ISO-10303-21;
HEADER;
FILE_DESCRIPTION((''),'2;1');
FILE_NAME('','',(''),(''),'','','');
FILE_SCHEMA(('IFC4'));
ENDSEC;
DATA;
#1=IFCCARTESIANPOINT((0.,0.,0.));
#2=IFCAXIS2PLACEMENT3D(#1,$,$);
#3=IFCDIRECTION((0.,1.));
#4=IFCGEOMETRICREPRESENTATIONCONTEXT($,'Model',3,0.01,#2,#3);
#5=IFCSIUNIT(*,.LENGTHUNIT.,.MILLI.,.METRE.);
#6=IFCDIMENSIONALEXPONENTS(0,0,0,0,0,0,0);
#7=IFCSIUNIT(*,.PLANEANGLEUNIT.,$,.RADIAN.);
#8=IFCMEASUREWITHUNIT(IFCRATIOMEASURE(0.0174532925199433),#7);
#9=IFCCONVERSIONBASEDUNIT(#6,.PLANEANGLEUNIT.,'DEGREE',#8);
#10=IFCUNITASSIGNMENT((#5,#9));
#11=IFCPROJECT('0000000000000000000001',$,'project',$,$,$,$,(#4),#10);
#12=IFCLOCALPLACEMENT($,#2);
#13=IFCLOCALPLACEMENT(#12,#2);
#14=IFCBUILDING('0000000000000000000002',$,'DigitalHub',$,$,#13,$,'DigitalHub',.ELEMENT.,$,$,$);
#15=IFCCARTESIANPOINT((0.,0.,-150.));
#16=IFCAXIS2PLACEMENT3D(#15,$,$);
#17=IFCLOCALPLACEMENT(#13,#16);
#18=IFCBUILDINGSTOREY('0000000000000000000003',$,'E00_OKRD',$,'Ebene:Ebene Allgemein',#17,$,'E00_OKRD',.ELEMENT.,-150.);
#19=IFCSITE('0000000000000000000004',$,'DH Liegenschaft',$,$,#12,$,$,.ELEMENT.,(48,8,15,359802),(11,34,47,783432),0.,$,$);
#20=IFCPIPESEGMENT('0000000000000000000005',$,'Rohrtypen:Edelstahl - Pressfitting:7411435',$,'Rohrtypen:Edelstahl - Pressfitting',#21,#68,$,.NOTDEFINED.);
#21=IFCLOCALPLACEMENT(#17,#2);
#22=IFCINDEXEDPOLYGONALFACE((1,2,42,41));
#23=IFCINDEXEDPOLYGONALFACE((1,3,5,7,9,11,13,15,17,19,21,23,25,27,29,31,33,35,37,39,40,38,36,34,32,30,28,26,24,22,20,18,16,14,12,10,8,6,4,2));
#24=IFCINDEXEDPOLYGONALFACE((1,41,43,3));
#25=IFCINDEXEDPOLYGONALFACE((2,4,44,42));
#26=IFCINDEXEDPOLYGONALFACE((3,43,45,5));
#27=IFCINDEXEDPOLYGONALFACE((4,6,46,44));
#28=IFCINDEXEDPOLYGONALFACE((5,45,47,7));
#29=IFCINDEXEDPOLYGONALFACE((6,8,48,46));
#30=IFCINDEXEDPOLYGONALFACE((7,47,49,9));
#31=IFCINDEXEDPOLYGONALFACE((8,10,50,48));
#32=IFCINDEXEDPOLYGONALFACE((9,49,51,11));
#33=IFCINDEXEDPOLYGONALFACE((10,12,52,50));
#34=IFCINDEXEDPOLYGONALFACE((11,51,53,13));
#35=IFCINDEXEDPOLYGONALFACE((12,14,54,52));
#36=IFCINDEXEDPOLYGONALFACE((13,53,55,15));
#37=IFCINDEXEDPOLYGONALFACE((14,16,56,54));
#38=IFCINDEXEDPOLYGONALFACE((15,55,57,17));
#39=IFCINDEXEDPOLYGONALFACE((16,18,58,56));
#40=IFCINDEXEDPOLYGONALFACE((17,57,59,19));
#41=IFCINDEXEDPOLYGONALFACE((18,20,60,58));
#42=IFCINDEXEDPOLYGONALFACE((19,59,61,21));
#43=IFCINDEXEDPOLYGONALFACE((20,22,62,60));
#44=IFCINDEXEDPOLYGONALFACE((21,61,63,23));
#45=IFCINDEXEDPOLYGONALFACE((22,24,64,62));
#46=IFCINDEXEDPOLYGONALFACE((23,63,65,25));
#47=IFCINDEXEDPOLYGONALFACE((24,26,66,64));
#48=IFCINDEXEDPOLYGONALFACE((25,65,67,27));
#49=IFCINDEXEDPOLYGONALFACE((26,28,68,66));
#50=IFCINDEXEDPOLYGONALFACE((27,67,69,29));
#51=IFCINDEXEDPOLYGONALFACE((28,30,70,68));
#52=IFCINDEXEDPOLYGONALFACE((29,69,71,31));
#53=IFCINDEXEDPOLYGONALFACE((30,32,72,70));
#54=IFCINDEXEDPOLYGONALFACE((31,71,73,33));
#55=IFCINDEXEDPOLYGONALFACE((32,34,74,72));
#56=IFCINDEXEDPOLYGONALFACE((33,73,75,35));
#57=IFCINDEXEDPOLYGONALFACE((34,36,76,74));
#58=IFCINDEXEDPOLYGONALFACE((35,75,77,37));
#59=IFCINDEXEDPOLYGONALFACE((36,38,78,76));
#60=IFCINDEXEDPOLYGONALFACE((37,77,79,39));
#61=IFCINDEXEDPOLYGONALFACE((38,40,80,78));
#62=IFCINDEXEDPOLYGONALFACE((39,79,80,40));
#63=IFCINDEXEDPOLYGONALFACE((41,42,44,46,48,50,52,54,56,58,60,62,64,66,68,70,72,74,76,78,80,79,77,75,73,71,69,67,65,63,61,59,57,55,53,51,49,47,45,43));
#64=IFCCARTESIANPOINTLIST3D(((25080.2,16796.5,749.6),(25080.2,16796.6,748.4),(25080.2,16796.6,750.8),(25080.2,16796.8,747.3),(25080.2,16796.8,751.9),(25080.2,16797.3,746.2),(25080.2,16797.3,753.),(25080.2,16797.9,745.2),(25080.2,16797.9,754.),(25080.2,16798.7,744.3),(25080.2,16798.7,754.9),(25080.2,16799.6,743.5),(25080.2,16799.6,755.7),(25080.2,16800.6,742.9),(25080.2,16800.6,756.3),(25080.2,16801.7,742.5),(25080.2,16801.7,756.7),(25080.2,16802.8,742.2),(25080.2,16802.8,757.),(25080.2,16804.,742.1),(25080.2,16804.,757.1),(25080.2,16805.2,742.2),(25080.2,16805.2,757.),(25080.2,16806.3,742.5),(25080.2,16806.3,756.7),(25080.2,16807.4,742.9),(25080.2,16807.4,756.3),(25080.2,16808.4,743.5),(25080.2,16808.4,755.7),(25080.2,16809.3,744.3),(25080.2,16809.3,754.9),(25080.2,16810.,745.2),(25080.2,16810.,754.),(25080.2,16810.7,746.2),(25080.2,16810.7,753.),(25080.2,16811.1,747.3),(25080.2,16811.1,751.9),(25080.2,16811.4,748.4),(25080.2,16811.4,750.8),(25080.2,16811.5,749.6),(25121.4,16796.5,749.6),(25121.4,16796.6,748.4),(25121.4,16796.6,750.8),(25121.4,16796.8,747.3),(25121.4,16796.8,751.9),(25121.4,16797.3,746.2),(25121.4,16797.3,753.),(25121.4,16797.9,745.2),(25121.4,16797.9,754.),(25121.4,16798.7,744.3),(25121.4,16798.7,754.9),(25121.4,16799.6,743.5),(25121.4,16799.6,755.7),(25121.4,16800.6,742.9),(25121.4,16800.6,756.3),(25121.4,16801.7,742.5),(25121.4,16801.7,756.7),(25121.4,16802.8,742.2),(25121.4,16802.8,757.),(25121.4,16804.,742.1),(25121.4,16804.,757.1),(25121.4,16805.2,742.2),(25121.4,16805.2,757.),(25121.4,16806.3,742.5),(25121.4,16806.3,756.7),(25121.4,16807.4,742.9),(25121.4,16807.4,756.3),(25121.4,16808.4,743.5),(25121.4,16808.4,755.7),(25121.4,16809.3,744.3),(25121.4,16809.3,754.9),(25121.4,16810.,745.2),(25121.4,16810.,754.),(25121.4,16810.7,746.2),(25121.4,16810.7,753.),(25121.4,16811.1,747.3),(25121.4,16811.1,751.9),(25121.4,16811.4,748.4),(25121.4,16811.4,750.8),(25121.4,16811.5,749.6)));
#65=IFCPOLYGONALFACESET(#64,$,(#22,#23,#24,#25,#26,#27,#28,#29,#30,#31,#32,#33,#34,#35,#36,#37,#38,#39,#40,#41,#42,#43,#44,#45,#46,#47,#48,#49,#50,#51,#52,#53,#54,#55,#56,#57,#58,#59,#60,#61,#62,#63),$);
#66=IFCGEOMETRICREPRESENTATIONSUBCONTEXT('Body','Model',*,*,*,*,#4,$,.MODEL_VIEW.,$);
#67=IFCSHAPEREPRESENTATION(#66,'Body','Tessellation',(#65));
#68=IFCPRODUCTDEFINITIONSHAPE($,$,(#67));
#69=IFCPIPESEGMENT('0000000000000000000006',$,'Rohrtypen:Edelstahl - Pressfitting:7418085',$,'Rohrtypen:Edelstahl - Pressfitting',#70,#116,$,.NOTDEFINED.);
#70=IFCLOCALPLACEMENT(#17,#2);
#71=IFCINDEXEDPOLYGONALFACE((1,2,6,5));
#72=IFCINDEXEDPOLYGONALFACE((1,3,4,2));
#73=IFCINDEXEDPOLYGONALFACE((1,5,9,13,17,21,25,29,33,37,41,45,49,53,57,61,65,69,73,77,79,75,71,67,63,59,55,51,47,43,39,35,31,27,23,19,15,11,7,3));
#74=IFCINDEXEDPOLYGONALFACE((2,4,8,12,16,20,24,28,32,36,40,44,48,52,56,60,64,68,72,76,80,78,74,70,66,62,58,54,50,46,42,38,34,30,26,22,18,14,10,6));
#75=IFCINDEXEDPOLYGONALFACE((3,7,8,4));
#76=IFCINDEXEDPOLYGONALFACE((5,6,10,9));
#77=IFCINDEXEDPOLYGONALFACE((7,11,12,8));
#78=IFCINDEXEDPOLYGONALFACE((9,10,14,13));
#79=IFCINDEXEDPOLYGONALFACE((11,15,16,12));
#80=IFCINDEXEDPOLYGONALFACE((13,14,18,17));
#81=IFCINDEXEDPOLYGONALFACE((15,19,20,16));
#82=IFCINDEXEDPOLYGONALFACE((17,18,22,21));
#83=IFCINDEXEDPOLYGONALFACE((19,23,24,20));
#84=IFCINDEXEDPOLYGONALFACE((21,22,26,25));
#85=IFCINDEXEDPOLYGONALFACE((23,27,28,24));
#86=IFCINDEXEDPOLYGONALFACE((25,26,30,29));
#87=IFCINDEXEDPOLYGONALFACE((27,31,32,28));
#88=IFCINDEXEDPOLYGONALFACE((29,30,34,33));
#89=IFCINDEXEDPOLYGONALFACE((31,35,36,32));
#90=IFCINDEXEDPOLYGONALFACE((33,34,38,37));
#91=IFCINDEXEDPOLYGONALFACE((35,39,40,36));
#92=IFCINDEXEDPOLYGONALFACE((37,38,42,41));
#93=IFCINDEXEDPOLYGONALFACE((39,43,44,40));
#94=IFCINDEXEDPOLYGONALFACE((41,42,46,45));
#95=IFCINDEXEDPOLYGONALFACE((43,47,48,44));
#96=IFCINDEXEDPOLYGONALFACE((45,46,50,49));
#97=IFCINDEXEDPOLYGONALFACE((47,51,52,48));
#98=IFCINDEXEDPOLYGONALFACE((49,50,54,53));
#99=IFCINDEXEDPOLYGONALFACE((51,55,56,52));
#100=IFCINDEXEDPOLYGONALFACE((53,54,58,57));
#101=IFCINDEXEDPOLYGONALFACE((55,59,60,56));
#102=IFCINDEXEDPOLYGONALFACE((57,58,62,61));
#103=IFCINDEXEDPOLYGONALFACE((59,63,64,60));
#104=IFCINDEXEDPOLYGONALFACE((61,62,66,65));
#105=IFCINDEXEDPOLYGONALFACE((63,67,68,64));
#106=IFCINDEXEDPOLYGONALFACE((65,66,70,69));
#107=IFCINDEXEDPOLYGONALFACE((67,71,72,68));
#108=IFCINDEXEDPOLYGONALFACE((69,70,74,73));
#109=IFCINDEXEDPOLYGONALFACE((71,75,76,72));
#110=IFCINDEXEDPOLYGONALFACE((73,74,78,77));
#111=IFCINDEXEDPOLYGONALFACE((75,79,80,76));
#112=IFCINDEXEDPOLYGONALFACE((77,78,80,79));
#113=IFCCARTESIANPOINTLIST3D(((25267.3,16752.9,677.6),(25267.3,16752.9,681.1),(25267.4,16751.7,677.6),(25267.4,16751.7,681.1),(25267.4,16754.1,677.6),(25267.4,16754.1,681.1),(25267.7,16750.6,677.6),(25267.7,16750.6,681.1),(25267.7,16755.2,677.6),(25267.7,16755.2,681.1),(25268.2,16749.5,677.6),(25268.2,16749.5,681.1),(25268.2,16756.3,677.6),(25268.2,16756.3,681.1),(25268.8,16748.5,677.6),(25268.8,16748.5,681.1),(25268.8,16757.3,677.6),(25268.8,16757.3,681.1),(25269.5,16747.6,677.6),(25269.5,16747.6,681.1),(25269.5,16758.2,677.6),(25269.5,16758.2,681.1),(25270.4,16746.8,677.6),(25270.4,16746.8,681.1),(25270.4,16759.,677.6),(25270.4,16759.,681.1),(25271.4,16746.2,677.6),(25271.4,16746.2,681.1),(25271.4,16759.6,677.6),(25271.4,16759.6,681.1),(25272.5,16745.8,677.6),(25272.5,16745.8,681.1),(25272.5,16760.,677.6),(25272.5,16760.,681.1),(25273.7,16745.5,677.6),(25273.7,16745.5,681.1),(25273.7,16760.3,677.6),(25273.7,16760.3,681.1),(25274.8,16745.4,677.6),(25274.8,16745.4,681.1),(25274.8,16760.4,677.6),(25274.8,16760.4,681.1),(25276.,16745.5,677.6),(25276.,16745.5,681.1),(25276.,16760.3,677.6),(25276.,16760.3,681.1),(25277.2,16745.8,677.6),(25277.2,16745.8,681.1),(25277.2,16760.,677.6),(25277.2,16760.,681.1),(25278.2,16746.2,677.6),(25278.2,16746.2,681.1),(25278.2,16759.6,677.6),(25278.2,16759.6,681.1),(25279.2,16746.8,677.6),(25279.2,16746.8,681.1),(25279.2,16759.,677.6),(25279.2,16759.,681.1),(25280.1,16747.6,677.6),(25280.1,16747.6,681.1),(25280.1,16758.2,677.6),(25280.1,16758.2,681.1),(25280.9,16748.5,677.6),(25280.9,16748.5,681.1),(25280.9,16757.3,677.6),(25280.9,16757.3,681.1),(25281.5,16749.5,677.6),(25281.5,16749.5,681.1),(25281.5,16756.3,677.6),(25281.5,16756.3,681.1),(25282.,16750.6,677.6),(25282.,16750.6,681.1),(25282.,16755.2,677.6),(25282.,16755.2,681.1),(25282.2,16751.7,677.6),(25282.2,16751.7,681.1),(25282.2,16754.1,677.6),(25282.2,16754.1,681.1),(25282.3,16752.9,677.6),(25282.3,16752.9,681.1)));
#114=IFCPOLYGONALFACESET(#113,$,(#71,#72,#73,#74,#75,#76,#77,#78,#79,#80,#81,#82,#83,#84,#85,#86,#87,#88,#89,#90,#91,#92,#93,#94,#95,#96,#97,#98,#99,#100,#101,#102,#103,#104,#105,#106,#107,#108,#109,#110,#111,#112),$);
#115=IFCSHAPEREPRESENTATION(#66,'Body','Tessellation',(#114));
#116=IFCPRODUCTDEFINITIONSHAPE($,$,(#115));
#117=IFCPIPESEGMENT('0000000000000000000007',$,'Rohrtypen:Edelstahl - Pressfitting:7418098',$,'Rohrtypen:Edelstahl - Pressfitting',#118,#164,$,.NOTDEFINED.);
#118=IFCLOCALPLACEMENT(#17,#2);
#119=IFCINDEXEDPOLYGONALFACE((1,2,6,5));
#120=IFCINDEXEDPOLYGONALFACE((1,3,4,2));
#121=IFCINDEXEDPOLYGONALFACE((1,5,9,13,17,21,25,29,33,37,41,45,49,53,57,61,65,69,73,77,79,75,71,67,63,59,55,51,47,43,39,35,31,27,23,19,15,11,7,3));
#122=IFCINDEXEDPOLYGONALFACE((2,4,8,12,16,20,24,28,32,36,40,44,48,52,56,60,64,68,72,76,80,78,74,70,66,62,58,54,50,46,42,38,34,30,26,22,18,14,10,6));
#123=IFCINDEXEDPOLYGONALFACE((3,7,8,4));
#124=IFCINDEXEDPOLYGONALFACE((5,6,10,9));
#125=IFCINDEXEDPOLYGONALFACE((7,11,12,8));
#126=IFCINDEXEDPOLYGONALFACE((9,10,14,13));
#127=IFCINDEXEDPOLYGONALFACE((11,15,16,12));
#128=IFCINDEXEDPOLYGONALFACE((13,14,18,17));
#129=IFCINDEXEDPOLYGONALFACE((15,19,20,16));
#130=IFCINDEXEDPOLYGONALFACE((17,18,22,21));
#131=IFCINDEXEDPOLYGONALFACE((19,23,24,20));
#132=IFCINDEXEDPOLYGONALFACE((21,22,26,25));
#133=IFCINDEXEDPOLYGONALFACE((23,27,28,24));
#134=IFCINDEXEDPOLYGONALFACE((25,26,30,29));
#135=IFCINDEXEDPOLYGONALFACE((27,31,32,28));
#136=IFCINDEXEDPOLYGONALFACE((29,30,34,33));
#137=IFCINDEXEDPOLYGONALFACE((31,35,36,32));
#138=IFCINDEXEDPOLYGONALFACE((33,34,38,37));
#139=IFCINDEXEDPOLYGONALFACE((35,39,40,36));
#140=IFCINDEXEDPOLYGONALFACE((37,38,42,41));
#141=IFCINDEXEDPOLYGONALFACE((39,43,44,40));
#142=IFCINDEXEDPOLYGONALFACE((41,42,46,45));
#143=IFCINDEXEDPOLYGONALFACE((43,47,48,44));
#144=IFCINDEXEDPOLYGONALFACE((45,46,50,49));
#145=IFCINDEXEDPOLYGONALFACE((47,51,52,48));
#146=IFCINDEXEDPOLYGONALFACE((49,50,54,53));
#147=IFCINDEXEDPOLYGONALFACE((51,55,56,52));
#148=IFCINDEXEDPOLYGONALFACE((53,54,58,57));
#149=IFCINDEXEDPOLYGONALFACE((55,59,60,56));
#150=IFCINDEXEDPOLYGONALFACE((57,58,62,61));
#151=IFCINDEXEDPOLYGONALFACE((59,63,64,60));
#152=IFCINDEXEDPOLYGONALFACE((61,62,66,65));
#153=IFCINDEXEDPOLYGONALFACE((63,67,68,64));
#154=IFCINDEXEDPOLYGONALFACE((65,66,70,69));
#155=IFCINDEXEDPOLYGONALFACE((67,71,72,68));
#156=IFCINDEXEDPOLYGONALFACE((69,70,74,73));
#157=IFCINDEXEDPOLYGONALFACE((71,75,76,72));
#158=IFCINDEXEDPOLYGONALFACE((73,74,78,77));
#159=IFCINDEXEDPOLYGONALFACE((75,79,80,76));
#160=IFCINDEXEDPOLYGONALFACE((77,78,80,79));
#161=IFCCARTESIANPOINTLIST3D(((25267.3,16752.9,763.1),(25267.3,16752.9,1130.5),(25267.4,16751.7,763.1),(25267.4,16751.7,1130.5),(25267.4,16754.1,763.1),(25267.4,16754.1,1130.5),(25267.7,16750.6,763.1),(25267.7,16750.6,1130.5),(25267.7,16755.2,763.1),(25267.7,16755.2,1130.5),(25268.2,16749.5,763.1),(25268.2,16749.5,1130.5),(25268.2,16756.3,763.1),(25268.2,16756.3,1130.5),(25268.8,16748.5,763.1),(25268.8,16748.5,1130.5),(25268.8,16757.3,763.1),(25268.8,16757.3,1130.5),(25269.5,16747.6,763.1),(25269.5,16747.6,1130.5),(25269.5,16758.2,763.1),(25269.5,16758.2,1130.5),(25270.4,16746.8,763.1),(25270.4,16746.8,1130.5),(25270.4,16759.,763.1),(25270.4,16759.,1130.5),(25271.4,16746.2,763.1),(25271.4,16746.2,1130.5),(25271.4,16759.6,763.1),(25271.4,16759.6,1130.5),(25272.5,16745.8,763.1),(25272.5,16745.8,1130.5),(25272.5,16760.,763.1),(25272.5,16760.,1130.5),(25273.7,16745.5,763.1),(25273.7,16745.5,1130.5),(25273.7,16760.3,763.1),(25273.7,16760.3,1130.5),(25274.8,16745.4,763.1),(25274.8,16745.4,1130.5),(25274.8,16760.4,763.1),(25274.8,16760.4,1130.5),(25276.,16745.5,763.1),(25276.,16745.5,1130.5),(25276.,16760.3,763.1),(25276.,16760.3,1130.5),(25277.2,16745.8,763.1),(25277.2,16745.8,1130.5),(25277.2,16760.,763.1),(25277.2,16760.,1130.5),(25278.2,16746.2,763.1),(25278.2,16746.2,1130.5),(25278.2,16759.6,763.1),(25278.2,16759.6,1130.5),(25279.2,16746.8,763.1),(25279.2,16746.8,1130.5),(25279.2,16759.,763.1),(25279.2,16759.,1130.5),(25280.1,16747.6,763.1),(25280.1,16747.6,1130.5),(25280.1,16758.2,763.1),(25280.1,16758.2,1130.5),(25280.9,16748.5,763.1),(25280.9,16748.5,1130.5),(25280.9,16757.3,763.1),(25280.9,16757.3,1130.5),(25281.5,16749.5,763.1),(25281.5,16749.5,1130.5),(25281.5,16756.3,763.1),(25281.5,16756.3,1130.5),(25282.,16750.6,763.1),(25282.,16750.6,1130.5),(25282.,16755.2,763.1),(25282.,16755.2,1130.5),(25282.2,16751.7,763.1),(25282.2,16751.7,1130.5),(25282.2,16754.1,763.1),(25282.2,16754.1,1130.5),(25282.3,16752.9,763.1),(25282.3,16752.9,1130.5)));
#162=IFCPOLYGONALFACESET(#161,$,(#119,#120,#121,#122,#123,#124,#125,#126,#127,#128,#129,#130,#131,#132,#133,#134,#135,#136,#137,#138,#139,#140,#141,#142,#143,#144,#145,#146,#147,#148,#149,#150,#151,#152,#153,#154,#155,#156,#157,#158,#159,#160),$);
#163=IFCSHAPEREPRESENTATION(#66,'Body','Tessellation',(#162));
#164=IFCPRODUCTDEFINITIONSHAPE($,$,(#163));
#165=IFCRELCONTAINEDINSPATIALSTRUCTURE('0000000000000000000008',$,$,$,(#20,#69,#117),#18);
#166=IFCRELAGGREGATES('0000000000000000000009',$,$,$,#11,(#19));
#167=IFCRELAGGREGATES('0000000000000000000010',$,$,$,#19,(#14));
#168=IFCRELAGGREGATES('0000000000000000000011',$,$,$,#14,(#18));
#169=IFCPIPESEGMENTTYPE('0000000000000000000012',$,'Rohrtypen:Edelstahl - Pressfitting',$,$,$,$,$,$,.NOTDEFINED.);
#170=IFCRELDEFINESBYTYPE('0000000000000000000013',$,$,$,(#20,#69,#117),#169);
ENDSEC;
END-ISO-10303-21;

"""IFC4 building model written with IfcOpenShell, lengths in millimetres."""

from ifc_helpers import new_model, entity, si_unit, converted_unit, direction, frame, origin, place, context, subcontext, project, spatial, indexed_curve, outline, extrude, type_object, element, save


model = new_model("IFC4")

# Units and contexts
model_context = context("Model", 3, precision=0.01, world=origin(), true_north=direction((0.0, 1.0)))
body_context = subcontext(model_context, "Body", "Model", "MODEL_VIEW")
ifc_project = project(units=[si_unit("LENGTHUNIT", "METRE", prefix="MILLI"), converted_unit("PLANEANGLEUNIT", "DEGREE", entity("IfcRatioMeasure", 0.0174532925199433), si_unit("PLANEANGLEUNIT", "RADIAN"), dimensions=[0, 0, 0, 0, 0, 0, 0])], contexts=[model_context])

# Site, building, storey
site_placement = place(None, origin())
site = spatial("IfcSite", under=ifc_project, at=site_placement, Name="DH Liegenschaft", CompositionType="ELEMENT", RefLatitude=(48, 8, 15, 359802), RefLongitude=(11, 34, 47, 783432), RefElevation=0.0)
building_placement = place(site_placement, origin())
building = spatial("IfcBuilding", under=site, at=building_placement, Name="DigitalHub", LongName="DigitalHub", CompositionType="ELEMENT")
storey_placement = place(building_placement, frame((0.0, 0.0, -150.0)))
storey = spatial("IfcBuildingStorey", under=building, at=storey_placement, Name="E00_OKRD", ObjectType="Ebene:Ebene Allgemein", LongName="E00_OKRD", CompositionType="ELEMENT", Elevation=-150.0)

# Pipe segments
pipe_segment_type_1 = type_object("IfcPipeSegmentType", Name="Rohrtypen:Edelstahl - Pressfitting", PredefinedType="NOTDEFINED")
pipe_segment_1_placement = place(storey_placement, frame((25080.2, 16794.9, 740.5)))
element("IfcPipeSegment", 1, at=pipe_segment_1_placement, inside=storey, type_object=pipe_segment_type_1, Name="Rohrtypen:Edelstahl - Pressfitting:7411435", ObjectType="Rohrtypen:Edelstahl - Pressfitting", PredefinedType="NOTDEFINED", context=body_context, shape_type="SweptSolid", body=[
    extrude(outline(indexed_curve([(7.5, 0.0), (7.4, 1.2), (7.1, 2.3), (6.7, 3.4), (6.1, 4.4), (5.3, 5.3), (4.4, 6.1), (3.4, 6.7), (2.3, 7.1), (1.2, 7.4), (0.0, 7.5), (-1.2, 7.4), (-2.3, 7.1), (-3.4, 6.7), (-4.4, 6.1), (-5.3, 5.3), (-6.1, 4.4), (-6.7, 3.4), (-7.1, 2.3), (-7.4, 1.2), (-7.5, 0.0), (-7.4, -1.2), (-7.1, -2.3), (-6.7, -3.4), (-6.1, -4.4), (-5.3, -5.3), (-4.4, -6.1), (-3.4, -6.7), (-2.3, -7.1), (-1.2, -7.4), (0.0, -7.5), (1.2, -7.4), (2.3, -7.1), (3.4, -6.7), (4.4, -6.1), (5.3, -5.3), (6.1, -4.4), (6.7, -3.4), (7.1, -2.3), (7.4, -1.2), (7.5, 0.0)], self_intersect=False)), frame((0.0, 9.1, 9.1), z_axis=(1.0, 0.0, 0.0), x_axis=(0.0, -1.0, 0.0)), (0.0, 0.0, 1.0), 41.2),
])
pipe_segment_2_placement = place(storey_placement, frame((25265.7, 16743.8, 677.6)))
element("IfcPipeSegment", 2, at=pipe_segment_2_placement, inside=storey, type_object=pipe_segment_type_1, Name="Rohrtypen:Edelstahl - Pressfitting:7418085", ObjectType="Rohrtypen:Edelstahl - Pressfitting", PredefinedType="NOTDEFINED", context=body_context, shape_type="SweptSolid", body=[
    extrude(outline(indexed_curve([(7.5, 0.0), (7.4, 1.2), (7.1, 2.3), (6.7, 3.4), (6.1, 4.4), (5.3, 5.3), (4.4, 6.1), (3.4, 6.7), (2.3, 7.1), (1.2, 7.4), (0.0, 7.5), (-1.2, 7.4), (-2.3, 7.1), (-3.4, 6.7), (-4.4, 6.1), (-5.3, 5.3), (-6.1, 4.4), (-6.7, 3.4), (-7.1, 2.3), (-7.4, 1.2), (-7.5, 0.0), (-7.4, -1.2), (-7.1, -2.3), (-6.7, -3.4), (-6.1, -4.4), (-5.3, -5.3), (-4.4, -6.1), (-3.4, -6.7), (-2.3, -7.1), (-1.2, -7.4), (0.0, -7.5), (1.2, -7.4), (2.3, -7.1), (3.4, -6.7), (4.4, -6.1), (5.3, -5.3), (6.1, -4.4), (6.7, -3.4), (7.1, -2.3), (7.4, -1.2), (7.5, 0.0)], self_intersect=False)), frame((9.1, 9.1, 0.0), z_axis=(0.0, 0.0, 1.0), x_axis=(-1.0, 0.0, 0.0)), (0.0, 0.0, 1.0), 3.5),
])
pipe_segment_3_placement = place(storey_placement, frame((25265.7, 16743.8, 763.1)))
element("IfcPipeSegment", 3, at=pipe_segment_3_placement, inside=storey, type_object=pipe_segment_type_1, Name="Rohrtypen:Edelstahl - Pressfitting:7418098", ObjectType="Rohrtypen:Edelstahl - Pressfitting", PredefinedType="NOTDEFINED", context=body_context, shape_type="SweptSolid", body=[
    extrude(outline(indexed_curve([(7.5, 0.0), (7.4, 1.2), (7.1, 2.3), (6.7, 3.4), (6.1, 4.4), (5.3, 5.3), (4.4, 6.1), (3.4, 6.7), (2.3, 7.1), (1.2, 7.4), (0.0, 7.5), (-1.2, 7.4), (-2.3, 7.1), (-3.4, 6.7), (-4.4, 6.1), (-5.3, 5.3), (-6.1, 4.4), (-6.7, 3.4), (-7.1, 2.3), (-7.4, 1.2), (-7.5, 0.0), (-7.4, -1.2), (-7.1, -2.3), (-6.7, -3.4), (-6.1, -4.4), (-5.3, -5.3), (-4.4, -6.1), (-3.4, -6.7), (-2.3, -7.1), (-1.2, -7.4), (0.0, -7.5), (1.2, -7.4), (2.3, -7.1), (3.4, -6.7), (4.4, -6.1), (5.3, -5.3), (6.1, -4.4), (6.7, -3.4), (7.1, -2.3), (7.4, -1.2), (7.5, 0.0)], self_intersect=False)), frame((9.1, 9.1, 0.0), z_axis=(0.0, 0.0, 1.0), x_axis=(-1.0, 0.0, 0.0)), (0.0, 0.0, 1.0), 367.4),
])

save(model, "model.ifc")
